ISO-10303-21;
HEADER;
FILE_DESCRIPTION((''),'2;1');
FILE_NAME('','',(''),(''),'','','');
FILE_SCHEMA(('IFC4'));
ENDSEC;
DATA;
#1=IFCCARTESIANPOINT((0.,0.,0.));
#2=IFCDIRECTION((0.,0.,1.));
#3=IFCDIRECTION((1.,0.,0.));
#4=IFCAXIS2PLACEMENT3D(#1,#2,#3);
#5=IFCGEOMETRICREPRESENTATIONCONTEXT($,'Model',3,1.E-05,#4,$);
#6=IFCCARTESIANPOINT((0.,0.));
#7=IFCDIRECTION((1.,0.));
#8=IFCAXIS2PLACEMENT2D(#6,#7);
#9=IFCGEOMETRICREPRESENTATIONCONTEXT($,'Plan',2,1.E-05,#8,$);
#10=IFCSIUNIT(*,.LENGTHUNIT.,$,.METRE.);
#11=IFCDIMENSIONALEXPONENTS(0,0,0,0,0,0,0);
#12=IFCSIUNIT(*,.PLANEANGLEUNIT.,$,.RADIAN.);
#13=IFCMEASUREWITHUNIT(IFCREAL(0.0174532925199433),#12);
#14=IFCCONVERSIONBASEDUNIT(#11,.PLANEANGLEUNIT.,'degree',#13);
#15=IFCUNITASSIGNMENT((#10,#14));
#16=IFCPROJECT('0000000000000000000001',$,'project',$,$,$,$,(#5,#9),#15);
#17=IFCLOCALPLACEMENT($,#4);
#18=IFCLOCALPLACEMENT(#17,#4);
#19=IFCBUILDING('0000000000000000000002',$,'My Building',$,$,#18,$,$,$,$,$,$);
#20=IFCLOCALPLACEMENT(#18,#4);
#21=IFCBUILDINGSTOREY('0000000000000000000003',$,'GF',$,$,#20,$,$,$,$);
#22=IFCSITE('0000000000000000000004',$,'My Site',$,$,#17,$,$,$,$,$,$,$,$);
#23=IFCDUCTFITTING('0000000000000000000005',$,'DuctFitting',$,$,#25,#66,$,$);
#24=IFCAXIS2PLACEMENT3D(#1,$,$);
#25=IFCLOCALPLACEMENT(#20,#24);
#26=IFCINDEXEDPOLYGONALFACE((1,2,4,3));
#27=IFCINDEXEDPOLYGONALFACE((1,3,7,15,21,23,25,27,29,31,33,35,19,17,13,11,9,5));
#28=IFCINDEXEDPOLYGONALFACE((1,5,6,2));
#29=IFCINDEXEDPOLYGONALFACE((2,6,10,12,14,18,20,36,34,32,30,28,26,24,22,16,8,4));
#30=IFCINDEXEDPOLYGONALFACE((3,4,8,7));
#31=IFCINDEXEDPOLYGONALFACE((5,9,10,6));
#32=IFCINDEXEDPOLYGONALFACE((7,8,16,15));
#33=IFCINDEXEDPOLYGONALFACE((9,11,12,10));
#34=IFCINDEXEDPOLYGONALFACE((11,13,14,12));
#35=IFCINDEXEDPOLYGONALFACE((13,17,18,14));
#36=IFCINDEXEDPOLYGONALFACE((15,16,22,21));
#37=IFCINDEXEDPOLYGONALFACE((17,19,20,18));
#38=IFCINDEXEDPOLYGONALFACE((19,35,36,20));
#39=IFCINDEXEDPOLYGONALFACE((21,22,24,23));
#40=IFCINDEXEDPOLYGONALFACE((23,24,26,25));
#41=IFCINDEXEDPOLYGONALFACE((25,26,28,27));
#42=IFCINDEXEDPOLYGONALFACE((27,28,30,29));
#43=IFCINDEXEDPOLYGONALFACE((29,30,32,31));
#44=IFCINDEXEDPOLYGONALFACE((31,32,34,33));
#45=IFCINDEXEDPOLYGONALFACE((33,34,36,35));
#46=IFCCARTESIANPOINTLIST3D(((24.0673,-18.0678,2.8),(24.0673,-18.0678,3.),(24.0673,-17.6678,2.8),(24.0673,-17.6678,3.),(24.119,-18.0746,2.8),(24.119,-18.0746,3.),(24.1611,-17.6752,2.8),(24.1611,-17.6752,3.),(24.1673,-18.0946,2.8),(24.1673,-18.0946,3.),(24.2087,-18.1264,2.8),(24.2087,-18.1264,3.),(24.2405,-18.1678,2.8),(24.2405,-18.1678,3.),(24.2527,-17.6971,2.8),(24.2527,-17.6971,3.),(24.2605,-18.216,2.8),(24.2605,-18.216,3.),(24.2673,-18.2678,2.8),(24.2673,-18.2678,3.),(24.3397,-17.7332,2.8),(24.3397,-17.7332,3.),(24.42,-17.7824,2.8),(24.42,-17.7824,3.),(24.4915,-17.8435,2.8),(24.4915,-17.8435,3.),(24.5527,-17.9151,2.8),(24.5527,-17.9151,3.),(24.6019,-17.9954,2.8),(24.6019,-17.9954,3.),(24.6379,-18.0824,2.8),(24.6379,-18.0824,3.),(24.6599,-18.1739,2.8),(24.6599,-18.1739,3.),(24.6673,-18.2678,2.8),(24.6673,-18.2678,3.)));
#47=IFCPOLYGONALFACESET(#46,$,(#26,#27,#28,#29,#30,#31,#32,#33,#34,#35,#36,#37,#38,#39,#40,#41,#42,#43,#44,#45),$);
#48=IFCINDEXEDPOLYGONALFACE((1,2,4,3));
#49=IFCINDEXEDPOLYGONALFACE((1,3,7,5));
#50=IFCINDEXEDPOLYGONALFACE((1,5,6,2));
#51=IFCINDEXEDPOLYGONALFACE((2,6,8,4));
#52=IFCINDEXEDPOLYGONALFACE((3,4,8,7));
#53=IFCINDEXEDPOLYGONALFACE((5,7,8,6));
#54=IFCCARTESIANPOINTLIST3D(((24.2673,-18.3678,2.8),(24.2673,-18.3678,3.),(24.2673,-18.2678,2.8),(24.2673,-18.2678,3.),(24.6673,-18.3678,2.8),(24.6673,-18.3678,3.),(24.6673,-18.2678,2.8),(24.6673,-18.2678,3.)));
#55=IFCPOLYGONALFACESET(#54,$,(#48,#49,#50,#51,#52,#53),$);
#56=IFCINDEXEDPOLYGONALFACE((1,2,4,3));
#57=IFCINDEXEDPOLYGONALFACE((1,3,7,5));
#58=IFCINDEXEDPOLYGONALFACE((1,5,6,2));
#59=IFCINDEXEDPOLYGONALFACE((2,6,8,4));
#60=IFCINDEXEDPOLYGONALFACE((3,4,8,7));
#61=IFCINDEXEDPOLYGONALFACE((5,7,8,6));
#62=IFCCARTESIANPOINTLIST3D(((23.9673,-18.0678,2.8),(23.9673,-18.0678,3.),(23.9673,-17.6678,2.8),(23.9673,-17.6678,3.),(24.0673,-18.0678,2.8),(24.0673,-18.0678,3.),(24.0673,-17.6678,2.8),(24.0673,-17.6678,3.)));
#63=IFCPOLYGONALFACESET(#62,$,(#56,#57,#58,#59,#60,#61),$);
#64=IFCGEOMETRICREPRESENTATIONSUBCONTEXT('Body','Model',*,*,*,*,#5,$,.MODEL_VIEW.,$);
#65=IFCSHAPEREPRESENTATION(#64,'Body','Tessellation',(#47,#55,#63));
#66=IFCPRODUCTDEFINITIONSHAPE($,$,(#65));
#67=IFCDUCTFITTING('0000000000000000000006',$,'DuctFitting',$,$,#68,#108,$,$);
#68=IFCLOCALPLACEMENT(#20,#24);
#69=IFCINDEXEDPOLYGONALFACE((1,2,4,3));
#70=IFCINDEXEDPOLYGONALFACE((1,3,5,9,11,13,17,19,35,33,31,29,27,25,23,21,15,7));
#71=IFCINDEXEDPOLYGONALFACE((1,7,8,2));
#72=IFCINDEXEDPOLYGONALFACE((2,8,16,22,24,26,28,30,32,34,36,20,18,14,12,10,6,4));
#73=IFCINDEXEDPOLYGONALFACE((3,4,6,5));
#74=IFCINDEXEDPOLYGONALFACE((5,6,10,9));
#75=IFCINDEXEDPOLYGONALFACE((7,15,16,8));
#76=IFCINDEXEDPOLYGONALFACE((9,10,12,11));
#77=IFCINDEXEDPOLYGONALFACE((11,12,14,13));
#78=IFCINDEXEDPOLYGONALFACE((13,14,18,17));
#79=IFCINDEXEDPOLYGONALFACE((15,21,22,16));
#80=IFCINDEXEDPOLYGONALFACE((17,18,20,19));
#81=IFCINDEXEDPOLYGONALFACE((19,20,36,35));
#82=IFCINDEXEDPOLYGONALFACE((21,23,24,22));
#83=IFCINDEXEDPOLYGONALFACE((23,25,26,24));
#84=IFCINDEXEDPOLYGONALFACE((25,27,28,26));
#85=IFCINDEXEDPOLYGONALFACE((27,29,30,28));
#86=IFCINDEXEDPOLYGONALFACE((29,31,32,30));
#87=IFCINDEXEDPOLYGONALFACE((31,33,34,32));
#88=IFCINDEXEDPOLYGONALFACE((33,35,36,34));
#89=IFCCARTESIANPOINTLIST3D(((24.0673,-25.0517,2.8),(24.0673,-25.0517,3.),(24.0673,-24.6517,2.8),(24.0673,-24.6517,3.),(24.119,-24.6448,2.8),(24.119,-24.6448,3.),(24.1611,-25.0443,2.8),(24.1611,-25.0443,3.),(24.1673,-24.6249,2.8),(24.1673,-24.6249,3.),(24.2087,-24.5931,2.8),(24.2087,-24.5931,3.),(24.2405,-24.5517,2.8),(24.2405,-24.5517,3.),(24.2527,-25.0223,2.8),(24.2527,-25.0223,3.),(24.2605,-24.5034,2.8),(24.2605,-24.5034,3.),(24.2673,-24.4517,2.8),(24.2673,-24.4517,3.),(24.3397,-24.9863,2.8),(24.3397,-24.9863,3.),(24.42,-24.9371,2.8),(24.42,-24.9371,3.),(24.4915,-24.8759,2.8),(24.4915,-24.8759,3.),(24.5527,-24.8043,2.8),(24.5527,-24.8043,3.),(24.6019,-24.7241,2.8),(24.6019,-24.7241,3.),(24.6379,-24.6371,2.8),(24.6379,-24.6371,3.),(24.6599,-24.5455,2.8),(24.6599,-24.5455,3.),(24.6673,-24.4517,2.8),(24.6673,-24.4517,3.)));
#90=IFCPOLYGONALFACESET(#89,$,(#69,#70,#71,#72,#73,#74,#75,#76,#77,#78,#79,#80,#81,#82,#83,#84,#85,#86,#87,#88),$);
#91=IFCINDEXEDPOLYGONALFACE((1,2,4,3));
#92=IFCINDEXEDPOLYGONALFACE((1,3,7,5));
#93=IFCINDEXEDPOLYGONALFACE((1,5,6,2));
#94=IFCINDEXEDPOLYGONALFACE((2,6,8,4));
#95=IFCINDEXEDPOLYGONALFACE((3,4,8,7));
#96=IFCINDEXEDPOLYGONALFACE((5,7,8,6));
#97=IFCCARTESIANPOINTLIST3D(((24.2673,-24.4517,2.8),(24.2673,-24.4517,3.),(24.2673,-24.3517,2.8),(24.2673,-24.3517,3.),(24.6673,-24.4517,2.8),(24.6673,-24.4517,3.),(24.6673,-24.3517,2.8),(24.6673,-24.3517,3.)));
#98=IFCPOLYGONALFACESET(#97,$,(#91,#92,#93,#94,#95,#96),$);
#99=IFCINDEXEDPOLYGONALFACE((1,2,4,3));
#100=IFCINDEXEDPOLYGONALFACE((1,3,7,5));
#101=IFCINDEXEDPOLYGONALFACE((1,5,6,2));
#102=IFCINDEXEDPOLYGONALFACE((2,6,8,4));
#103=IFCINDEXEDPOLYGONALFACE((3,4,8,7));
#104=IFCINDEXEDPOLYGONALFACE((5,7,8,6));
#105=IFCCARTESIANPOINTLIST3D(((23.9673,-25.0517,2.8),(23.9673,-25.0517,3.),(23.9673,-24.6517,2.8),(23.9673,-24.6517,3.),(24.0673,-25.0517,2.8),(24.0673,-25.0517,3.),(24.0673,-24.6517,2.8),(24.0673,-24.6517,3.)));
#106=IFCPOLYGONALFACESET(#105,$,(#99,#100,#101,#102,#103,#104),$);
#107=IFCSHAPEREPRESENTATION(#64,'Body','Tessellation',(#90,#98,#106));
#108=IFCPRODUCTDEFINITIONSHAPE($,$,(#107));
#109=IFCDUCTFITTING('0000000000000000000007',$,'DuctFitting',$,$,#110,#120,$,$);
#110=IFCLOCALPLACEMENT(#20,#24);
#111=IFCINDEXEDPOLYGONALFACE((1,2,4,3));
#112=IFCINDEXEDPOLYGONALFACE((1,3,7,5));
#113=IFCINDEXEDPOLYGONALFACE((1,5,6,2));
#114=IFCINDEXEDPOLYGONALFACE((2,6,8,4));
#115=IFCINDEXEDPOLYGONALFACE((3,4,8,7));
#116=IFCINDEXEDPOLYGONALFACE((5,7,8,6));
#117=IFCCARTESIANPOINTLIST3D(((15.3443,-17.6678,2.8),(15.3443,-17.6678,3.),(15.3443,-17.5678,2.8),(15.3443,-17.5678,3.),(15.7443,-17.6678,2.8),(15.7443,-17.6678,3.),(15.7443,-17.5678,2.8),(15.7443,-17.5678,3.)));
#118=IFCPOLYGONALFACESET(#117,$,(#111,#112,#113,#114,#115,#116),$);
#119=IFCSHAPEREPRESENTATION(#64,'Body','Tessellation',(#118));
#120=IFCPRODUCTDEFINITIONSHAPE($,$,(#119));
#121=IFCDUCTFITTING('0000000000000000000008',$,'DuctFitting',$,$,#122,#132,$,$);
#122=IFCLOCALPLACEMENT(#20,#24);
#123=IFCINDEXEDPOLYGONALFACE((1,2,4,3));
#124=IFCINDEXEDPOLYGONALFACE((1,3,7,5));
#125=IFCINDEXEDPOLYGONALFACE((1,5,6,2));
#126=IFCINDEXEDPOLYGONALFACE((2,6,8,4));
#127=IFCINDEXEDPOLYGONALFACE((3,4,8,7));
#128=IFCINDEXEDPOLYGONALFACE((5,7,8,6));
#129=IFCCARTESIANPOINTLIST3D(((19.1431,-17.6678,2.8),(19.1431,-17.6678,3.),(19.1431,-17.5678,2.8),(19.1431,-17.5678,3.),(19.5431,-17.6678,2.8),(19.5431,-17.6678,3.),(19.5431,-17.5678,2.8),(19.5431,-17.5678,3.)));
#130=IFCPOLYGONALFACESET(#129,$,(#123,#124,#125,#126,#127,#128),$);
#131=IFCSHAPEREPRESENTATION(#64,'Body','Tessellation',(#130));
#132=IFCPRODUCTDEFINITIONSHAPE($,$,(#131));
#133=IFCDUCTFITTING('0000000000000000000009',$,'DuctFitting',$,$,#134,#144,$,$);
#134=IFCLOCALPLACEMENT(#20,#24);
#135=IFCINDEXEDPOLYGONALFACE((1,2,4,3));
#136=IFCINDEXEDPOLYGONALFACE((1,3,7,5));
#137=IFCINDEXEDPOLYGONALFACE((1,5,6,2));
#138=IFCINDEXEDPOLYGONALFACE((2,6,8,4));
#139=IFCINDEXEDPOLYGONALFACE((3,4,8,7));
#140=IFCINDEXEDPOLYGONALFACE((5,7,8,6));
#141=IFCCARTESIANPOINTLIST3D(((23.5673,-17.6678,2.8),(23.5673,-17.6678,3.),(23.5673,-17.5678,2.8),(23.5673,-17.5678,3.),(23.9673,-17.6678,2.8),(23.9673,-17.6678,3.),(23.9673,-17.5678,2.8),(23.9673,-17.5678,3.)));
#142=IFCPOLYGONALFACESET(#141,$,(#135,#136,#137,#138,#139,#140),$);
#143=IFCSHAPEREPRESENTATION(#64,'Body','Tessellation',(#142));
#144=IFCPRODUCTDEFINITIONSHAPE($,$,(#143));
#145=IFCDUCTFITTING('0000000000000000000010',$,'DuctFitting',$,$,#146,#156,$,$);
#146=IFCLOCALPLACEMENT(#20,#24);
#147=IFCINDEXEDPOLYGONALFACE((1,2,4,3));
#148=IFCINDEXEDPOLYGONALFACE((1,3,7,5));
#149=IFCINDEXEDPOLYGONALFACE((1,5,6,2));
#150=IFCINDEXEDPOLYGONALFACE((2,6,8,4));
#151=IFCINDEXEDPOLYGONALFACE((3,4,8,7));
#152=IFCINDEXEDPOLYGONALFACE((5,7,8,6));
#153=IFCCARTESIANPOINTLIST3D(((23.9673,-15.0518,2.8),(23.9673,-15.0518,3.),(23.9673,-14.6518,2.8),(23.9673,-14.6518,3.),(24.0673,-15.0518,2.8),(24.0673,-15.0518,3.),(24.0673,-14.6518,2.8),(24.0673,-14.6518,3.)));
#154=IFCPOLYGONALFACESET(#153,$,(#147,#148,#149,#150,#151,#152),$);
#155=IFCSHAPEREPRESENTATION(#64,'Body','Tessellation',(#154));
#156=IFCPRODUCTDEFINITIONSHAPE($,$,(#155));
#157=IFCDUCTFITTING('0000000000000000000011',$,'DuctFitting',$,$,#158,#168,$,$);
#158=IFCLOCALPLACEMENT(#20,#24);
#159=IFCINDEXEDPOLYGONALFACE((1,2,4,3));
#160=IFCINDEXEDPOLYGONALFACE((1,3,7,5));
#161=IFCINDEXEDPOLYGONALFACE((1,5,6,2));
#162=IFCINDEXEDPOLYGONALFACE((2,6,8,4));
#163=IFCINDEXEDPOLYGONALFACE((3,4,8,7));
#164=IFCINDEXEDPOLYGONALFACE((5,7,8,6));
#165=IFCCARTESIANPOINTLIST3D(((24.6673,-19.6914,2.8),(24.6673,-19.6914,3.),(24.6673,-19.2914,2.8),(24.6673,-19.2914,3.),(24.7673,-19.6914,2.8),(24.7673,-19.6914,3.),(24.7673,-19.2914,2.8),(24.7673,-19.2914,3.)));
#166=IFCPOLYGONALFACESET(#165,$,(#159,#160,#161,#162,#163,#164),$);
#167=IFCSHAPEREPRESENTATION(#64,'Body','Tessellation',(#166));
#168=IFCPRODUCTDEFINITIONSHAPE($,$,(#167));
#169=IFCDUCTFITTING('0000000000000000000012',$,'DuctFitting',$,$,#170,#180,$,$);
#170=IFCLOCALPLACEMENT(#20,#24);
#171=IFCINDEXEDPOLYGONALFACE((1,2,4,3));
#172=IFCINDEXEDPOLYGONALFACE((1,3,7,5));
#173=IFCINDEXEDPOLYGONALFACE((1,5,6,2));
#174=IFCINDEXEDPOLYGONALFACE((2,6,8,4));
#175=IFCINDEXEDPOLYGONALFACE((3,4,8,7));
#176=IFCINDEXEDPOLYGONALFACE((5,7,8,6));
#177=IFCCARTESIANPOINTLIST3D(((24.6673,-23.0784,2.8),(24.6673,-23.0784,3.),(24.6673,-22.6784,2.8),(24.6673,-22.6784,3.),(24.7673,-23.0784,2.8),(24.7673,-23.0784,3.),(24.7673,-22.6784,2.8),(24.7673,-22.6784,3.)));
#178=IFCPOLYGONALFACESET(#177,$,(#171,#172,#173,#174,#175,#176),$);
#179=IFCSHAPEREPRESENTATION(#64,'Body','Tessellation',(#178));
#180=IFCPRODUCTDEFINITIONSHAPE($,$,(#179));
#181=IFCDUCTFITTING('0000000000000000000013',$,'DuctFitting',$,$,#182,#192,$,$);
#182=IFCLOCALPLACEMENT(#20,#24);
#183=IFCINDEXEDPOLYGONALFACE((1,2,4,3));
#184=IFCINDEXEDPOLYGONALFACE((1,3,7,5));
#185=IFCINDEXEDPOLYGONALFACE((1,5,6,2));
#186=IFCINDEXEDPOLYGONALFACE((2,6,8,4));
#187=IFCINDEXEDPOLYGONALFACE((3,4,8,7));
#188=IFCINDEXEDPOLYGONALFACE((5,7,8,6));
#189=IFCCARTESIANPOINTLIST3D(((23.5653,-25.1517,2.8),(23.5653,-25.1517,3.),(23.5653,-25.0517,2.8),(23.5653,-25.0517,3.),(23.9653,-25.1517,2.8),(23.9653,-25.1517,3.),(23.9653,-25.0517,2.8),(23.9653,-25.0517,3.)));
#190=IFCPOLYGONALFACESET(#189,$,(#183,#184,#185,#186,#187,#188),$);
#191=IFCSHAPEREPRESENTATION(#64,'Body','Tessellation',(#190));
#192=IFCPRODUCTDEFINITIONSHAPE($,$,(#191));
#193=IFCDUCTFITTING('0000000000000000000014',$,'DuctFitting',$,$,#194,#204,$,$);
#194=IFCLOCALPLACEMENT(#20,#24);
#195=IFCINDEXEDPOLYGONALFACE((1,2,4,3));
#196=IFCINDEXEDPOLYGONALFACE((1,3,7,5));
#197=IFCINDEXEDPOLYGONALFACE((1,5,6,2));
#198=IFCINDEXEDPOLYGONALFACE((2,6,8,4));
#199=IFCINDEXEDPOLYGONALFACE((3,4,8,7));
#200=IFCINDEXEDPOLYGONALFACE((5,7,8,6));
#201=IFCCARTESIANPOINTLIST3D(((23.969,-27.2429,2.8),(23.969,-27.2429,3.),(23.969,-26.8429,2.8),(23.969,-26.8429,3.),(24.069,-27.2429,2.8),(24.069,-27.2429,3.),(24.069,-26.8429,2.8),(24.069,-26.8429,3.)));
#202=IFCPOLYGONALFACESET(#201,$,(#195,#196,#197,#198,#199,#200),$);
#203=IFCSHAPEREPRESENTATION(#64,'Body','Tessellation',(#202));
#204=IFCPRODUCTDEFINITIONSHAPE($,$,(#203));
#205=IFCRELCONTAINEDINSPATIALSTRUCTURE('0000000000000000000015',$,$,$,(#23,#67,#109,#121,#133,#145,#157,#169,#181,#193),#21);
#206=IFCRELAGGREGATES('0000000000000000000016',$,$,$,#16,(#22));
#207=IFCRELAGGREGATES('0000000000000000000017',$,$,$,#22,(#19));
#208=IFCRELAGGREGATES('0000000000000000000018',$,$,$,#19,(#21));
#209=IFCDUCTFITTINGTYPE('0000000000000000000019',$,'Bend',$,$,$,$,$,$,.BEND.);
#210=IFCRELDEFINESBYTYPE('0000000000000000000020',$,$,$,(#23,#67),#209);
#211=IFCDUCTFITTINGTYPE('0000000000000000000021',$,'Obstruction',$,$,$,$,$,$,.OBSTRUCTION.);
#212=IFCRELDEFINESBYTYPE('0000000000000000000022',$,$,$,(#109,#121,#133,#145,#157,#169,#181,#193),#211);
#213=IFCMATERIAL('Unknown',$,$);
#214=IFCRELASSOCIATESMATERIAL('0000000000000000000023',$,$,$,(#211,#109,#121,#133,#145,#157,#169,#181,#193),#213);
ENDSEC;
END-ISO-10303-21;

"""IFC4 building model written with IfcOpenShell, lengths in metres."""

from ifc_helpers import new_model, entity, si_unit, converted_unit, frame, origin_with_axes, origin_2d_with_axis, place, context, subcontext, project, spatial, line, arc, indexed_curve, rectangle, outline, extrude, source, transform, mapped, material, material_profile, profile_set, profile_usage, type_object, type_shapes, element, save


model = new_model("IFC4")

# Units and contexts
model_context = context("Model", 3, precision=1e-05, world=origin_with_axes())
plan_context = context("Plan", 2, precision=1e-05, world=origin_2d_with_axis())
body_context_1 = subcontext(model_context, "Body", "Model", "MODEL_VIEW")
ifc_project = project(units=[si_unit("LENGTHUNIT", "METRE"), converted_unit("PLANEANGLEUNIT", "degree", entity("IfcReal", 0.0174532925199433), si_unit("PLANEANGLEUNIT", "RADIAN"), dimensions=[0, 0, 0, 0, 0, 0, 0])], contexts=[model_context, plan_context])

# Site, building, storey
site_placement = place(None, origin_with_axes())
site = spatial("IfcSite", under=ifc_project, at=site_placement, Name="My Site")
building_placement = place(site_placement, origin_with_axes())
building = spatial("IfcBuilding", under=site, at=building_placement, Name="My Building")
storey_placement = place(building_placement, origin_with_axes())
storey = spatial("IfcBuildingStorey", under=building, at=storey_placement, Name="GF")

# Shared definitions
ifc_material = material(Name="Unknown")

# Duct fittings
duct_fitting_type_1 = type_object("IfcDuctFittingType", Name="Bend", PredefinedType="BEND")
shared_shape_1 = source(origin_with_axes(), body_context_1, "Body", "SweptSolid", [
    extrude(outline(indexed_curve([(0.2, 0.0), (0.2586, 0.1414), (0.4, 0.2), (0.4, 0.6), (-0.0243, 0.4243), (-0.2, 0.0)], segments=[arc(1, 2, 3), line(3, 4), arc(4, 5, 6), line(6, 1)])), frame((0.0, -0.1, 0.1), z_axis=(0.0, -1.0, 0.0), x_axis=(1.0, 0.0, 0.0)), (0.0, 0.0, -1.0), 0.2),
    extrude(rectangle(XDim=0.4, YDim=0.2), origin_with_axes(), (0.0, 0.0, 1.0), 0.1),
    extrude(rectangle(XDim=0.4, YDim=0.2), frame((0.4, 0.0, 0.5), z_axis=(1.0, 0.0, 0.0), x_axis=(0.0, 0.0, 1.0)), (0.0, 0.0, 1.0), 0.1),
])
type_shapes(duct_fitting_type_1, [shared_shape_1])
for number, where, z_axis, x_axis, name in (
    (1, (24.4673, -18.3678, 2.9), (0.0, 1.0, 0.0), (-1.0, 0.0, 0.0), "DuctFitting"),
    (2, (24.4673, -24.3517, 2.9), (0.0, -1.0, 0.0), (-1.0, 0.0, 0.0), "DuctFitting"),
):
    element("IfcDuctFitting", number, at=place(storey_placement, frame(where, z_axis=z_axis, x_axis=x_axis)), inside=storey, type_object=duct_fitting_type_1, Name=name, context=body_context_1, shape_type="MappedRepresentation", body=[
        mapped(shared_shape_1, transform((0.0, 0.0, 0.0), x_axis=(1.0, 0.0, 0.0), y_axis=(0.0, 1.0, 0.0), z_axis=(0.0, 0.0, 1.0), scale=1.0)),
    ])
ifc_material_profile_1 = material_profile(ifc_material, rectangle(XDim=0.4, YDim=0.2))
ifc_profile_set_1 = profile_set([ifc_material_profile_1])
ifc_profile_usage_1 = profile_usage(ifc_profile_set_1, cardinal=5)
duct_fitting_type_2 = type_object("IfcDuctFittingType", Name="Obstruction", PredefinedType="OBSTRUCTION", material=ifc_profile_set_1)
duct_fitting_1_placement = place(storey_placement, frame((15.5443, -17.6678, 2.9), z_axis=(0.0, 1.0, 0.0), x_axis=(-1.0, 0.0, 0.0)))
element("IfcDuctFitting", 3, at=duct_fitting_1_placement, inside=storey, type_object=duct_fitting_type_2, material=ifc_profile_usage_1, Name="DuctFitting", context=body_context_1, shape_type="SweptSolid", body=[
    extrude(rectangle(XDim=0.4, YDim=0.2), origin_with_axes(), (0.0, 0.0, 1.0), 0.1),
])
ifc_profile_usage_2 = profile_usage(ifc_profile_set_1, cardinal=5)
duct_fitting_2_placement = place(storey_placement, frame((19.3431, -17.6678, 2.9), z_axis=(0.0, 1.0, 0.0), x_axis=(-1.0, 0.0, 0.0)))
element("IfcDuctFitting", 4, at=duct_fitting_2_placement, inside=storey, type_object=duct_fitting_type_2, material=ifc_profile_usage_2, Name="DuctFitting", context=body_context_1, shape_type="SweptSolid", body=[
    extrude(rectangle(XDim=0.4, YDim=0.2), origin_with_axes(), (0.0, 0.0, 1.0), 0.1),
])
ifc_profile_usage_3 = profile_usage(ifc_profile_set_1, cardinal=5)
duct_fitting_3_placement = place(storey_placement, frame((23.7673, -17.6678, 2.9), z_axis=(0.0, 1.0, 0.0), x_axis=(-1.0, 0.0, 0.0)))
element("IfcDuctFitting", 5, at=duct_fitting_3_placement, inside=storey, type_object=duct_fitting_type_2, material=ifc_profile_usage_3, Name="DuctFitting", context=body_context_1, shape_type="SweptSolid", body=[
    extrude(rectangle(XDim=0.4, YDim=0.2), origin_with_axes(), (0.0, 0.0, 1.0), 0.1),
])
ifc_profile_usage_4 = profile_usage(ifc_profile_set_1, cardinal=5)
duct_fitting_4_placement = place(storey_placement, frame((23.9673, -14.8518, 2.9), z_axis=(1.0, 0.0, 0.0), x_axis=(0.0, 1.0, 0.0)))
element("IfcDuctFitting", 6, at=duct_fitting_4_placement, inside=storey, type_object=duct_fitting_type_2, material=ifc_profile_usage_4, Name="DuctFitting", context=body_context_1, shape_type="SweptSolid", body=[
    extrude(rectangle(XDim=0.4, YDim=0.2), origin_with_axes(), (0.0, 0.0, 1.0), 0.1),
])
ifc_profile_usage_5 = profile_usage(ifc_profile_set_1, cardinal=5)
duct_fitting_5_placement = place(storey_placement, frame((24.6673, -19.4914, 2.9), z_axis=(1.0, 0.0, 0.0), x_axis=(0.0, 1.0, 0.0)))
element("IfcDuctFitting", 7, at=duct_fitting_5_placement, inside=storey, type_object=duct_fitting_type_2, material=ifc_profile_usage_5, Name="DuctFitting", context=body_context_1, shape_type="SweptSolid", body=[
    extrude(rectangle(XDim=0.4, YDim=0.2), origin_with_axes(), (0.0, 0.0, 1.0), 0.1),
])
ifc_profile_usage_6 = profile_usage(ifc_profile_set_1, cardinal=5)
duct_fitting_6_placement = place(storey_placement, frame((24.6673, -22.8784, 2.9), z_axis=(1.0, 0.0, 0.0), x_axis=(0.0, 1.0, 0.0)))
element("IfcDuctFitting", 8, at=duct_fitting_6_placement, inside=storey, type_object=duct_fitting_type_2, material=ifc_profile_usage_6, Name="DuctFitting", context=body_context_1, shape_type="SweptSolid", body=[
    extrude(rectangle(XDim=0.4, YDim=0.2), origin_with_axes(), (0.0, 0.0, 1.0), 0.1),
])
ifc_profile_usage_7 = profile_usage(ifc_profile_set_1, cardinal=5)
duct_fitting_7_placement = place(storey_placement, frame((23.7653, -25.0517, 2.9), z_axis=(0.0, -1.0, 0.0), x_axis=(1.0, 0.0, 0.0)))
element("IfcDuctFitting", 9, at=duct_fitting_7_placement, inside=storey, type_object=duct_fitting_type_2, material=ifc_profile_usage_7, Name="DuctFitting", context=body_context_1, shape_type="SweptSolid", body=[
    extrude(rectangle(XDim=0.4, YDim=0.2), origin_with_axes(), (0.0, 0.0, 1.0), 0.1),
])
ifc_profile_usage_8 = profile_usage(ifc_profile_set_1, cardinal=5)
duct_fitting_8_placement = place(storey_placement, frame((23.969, -27.0429, 2.9), z_axis=(1.0, 0.0, 0.0), x_axis=(0.0, 1.0, 0.0)))
element("IfcDuctFitting", 10, at=duct_fitting_8_placement, inside=storey, type_object=duct_fitting_type_2, material=ifc_profile_usage_8, Name="DuctFitting", context=body_context_1, shape_type="SweptSolid", body=[
    extrude(rectangle(XDim=0.4, YDim=0.2), origin_with_axes(), (0.0, 0.0, 1.0), 0.1),
])

save(model, "model.ifc")
